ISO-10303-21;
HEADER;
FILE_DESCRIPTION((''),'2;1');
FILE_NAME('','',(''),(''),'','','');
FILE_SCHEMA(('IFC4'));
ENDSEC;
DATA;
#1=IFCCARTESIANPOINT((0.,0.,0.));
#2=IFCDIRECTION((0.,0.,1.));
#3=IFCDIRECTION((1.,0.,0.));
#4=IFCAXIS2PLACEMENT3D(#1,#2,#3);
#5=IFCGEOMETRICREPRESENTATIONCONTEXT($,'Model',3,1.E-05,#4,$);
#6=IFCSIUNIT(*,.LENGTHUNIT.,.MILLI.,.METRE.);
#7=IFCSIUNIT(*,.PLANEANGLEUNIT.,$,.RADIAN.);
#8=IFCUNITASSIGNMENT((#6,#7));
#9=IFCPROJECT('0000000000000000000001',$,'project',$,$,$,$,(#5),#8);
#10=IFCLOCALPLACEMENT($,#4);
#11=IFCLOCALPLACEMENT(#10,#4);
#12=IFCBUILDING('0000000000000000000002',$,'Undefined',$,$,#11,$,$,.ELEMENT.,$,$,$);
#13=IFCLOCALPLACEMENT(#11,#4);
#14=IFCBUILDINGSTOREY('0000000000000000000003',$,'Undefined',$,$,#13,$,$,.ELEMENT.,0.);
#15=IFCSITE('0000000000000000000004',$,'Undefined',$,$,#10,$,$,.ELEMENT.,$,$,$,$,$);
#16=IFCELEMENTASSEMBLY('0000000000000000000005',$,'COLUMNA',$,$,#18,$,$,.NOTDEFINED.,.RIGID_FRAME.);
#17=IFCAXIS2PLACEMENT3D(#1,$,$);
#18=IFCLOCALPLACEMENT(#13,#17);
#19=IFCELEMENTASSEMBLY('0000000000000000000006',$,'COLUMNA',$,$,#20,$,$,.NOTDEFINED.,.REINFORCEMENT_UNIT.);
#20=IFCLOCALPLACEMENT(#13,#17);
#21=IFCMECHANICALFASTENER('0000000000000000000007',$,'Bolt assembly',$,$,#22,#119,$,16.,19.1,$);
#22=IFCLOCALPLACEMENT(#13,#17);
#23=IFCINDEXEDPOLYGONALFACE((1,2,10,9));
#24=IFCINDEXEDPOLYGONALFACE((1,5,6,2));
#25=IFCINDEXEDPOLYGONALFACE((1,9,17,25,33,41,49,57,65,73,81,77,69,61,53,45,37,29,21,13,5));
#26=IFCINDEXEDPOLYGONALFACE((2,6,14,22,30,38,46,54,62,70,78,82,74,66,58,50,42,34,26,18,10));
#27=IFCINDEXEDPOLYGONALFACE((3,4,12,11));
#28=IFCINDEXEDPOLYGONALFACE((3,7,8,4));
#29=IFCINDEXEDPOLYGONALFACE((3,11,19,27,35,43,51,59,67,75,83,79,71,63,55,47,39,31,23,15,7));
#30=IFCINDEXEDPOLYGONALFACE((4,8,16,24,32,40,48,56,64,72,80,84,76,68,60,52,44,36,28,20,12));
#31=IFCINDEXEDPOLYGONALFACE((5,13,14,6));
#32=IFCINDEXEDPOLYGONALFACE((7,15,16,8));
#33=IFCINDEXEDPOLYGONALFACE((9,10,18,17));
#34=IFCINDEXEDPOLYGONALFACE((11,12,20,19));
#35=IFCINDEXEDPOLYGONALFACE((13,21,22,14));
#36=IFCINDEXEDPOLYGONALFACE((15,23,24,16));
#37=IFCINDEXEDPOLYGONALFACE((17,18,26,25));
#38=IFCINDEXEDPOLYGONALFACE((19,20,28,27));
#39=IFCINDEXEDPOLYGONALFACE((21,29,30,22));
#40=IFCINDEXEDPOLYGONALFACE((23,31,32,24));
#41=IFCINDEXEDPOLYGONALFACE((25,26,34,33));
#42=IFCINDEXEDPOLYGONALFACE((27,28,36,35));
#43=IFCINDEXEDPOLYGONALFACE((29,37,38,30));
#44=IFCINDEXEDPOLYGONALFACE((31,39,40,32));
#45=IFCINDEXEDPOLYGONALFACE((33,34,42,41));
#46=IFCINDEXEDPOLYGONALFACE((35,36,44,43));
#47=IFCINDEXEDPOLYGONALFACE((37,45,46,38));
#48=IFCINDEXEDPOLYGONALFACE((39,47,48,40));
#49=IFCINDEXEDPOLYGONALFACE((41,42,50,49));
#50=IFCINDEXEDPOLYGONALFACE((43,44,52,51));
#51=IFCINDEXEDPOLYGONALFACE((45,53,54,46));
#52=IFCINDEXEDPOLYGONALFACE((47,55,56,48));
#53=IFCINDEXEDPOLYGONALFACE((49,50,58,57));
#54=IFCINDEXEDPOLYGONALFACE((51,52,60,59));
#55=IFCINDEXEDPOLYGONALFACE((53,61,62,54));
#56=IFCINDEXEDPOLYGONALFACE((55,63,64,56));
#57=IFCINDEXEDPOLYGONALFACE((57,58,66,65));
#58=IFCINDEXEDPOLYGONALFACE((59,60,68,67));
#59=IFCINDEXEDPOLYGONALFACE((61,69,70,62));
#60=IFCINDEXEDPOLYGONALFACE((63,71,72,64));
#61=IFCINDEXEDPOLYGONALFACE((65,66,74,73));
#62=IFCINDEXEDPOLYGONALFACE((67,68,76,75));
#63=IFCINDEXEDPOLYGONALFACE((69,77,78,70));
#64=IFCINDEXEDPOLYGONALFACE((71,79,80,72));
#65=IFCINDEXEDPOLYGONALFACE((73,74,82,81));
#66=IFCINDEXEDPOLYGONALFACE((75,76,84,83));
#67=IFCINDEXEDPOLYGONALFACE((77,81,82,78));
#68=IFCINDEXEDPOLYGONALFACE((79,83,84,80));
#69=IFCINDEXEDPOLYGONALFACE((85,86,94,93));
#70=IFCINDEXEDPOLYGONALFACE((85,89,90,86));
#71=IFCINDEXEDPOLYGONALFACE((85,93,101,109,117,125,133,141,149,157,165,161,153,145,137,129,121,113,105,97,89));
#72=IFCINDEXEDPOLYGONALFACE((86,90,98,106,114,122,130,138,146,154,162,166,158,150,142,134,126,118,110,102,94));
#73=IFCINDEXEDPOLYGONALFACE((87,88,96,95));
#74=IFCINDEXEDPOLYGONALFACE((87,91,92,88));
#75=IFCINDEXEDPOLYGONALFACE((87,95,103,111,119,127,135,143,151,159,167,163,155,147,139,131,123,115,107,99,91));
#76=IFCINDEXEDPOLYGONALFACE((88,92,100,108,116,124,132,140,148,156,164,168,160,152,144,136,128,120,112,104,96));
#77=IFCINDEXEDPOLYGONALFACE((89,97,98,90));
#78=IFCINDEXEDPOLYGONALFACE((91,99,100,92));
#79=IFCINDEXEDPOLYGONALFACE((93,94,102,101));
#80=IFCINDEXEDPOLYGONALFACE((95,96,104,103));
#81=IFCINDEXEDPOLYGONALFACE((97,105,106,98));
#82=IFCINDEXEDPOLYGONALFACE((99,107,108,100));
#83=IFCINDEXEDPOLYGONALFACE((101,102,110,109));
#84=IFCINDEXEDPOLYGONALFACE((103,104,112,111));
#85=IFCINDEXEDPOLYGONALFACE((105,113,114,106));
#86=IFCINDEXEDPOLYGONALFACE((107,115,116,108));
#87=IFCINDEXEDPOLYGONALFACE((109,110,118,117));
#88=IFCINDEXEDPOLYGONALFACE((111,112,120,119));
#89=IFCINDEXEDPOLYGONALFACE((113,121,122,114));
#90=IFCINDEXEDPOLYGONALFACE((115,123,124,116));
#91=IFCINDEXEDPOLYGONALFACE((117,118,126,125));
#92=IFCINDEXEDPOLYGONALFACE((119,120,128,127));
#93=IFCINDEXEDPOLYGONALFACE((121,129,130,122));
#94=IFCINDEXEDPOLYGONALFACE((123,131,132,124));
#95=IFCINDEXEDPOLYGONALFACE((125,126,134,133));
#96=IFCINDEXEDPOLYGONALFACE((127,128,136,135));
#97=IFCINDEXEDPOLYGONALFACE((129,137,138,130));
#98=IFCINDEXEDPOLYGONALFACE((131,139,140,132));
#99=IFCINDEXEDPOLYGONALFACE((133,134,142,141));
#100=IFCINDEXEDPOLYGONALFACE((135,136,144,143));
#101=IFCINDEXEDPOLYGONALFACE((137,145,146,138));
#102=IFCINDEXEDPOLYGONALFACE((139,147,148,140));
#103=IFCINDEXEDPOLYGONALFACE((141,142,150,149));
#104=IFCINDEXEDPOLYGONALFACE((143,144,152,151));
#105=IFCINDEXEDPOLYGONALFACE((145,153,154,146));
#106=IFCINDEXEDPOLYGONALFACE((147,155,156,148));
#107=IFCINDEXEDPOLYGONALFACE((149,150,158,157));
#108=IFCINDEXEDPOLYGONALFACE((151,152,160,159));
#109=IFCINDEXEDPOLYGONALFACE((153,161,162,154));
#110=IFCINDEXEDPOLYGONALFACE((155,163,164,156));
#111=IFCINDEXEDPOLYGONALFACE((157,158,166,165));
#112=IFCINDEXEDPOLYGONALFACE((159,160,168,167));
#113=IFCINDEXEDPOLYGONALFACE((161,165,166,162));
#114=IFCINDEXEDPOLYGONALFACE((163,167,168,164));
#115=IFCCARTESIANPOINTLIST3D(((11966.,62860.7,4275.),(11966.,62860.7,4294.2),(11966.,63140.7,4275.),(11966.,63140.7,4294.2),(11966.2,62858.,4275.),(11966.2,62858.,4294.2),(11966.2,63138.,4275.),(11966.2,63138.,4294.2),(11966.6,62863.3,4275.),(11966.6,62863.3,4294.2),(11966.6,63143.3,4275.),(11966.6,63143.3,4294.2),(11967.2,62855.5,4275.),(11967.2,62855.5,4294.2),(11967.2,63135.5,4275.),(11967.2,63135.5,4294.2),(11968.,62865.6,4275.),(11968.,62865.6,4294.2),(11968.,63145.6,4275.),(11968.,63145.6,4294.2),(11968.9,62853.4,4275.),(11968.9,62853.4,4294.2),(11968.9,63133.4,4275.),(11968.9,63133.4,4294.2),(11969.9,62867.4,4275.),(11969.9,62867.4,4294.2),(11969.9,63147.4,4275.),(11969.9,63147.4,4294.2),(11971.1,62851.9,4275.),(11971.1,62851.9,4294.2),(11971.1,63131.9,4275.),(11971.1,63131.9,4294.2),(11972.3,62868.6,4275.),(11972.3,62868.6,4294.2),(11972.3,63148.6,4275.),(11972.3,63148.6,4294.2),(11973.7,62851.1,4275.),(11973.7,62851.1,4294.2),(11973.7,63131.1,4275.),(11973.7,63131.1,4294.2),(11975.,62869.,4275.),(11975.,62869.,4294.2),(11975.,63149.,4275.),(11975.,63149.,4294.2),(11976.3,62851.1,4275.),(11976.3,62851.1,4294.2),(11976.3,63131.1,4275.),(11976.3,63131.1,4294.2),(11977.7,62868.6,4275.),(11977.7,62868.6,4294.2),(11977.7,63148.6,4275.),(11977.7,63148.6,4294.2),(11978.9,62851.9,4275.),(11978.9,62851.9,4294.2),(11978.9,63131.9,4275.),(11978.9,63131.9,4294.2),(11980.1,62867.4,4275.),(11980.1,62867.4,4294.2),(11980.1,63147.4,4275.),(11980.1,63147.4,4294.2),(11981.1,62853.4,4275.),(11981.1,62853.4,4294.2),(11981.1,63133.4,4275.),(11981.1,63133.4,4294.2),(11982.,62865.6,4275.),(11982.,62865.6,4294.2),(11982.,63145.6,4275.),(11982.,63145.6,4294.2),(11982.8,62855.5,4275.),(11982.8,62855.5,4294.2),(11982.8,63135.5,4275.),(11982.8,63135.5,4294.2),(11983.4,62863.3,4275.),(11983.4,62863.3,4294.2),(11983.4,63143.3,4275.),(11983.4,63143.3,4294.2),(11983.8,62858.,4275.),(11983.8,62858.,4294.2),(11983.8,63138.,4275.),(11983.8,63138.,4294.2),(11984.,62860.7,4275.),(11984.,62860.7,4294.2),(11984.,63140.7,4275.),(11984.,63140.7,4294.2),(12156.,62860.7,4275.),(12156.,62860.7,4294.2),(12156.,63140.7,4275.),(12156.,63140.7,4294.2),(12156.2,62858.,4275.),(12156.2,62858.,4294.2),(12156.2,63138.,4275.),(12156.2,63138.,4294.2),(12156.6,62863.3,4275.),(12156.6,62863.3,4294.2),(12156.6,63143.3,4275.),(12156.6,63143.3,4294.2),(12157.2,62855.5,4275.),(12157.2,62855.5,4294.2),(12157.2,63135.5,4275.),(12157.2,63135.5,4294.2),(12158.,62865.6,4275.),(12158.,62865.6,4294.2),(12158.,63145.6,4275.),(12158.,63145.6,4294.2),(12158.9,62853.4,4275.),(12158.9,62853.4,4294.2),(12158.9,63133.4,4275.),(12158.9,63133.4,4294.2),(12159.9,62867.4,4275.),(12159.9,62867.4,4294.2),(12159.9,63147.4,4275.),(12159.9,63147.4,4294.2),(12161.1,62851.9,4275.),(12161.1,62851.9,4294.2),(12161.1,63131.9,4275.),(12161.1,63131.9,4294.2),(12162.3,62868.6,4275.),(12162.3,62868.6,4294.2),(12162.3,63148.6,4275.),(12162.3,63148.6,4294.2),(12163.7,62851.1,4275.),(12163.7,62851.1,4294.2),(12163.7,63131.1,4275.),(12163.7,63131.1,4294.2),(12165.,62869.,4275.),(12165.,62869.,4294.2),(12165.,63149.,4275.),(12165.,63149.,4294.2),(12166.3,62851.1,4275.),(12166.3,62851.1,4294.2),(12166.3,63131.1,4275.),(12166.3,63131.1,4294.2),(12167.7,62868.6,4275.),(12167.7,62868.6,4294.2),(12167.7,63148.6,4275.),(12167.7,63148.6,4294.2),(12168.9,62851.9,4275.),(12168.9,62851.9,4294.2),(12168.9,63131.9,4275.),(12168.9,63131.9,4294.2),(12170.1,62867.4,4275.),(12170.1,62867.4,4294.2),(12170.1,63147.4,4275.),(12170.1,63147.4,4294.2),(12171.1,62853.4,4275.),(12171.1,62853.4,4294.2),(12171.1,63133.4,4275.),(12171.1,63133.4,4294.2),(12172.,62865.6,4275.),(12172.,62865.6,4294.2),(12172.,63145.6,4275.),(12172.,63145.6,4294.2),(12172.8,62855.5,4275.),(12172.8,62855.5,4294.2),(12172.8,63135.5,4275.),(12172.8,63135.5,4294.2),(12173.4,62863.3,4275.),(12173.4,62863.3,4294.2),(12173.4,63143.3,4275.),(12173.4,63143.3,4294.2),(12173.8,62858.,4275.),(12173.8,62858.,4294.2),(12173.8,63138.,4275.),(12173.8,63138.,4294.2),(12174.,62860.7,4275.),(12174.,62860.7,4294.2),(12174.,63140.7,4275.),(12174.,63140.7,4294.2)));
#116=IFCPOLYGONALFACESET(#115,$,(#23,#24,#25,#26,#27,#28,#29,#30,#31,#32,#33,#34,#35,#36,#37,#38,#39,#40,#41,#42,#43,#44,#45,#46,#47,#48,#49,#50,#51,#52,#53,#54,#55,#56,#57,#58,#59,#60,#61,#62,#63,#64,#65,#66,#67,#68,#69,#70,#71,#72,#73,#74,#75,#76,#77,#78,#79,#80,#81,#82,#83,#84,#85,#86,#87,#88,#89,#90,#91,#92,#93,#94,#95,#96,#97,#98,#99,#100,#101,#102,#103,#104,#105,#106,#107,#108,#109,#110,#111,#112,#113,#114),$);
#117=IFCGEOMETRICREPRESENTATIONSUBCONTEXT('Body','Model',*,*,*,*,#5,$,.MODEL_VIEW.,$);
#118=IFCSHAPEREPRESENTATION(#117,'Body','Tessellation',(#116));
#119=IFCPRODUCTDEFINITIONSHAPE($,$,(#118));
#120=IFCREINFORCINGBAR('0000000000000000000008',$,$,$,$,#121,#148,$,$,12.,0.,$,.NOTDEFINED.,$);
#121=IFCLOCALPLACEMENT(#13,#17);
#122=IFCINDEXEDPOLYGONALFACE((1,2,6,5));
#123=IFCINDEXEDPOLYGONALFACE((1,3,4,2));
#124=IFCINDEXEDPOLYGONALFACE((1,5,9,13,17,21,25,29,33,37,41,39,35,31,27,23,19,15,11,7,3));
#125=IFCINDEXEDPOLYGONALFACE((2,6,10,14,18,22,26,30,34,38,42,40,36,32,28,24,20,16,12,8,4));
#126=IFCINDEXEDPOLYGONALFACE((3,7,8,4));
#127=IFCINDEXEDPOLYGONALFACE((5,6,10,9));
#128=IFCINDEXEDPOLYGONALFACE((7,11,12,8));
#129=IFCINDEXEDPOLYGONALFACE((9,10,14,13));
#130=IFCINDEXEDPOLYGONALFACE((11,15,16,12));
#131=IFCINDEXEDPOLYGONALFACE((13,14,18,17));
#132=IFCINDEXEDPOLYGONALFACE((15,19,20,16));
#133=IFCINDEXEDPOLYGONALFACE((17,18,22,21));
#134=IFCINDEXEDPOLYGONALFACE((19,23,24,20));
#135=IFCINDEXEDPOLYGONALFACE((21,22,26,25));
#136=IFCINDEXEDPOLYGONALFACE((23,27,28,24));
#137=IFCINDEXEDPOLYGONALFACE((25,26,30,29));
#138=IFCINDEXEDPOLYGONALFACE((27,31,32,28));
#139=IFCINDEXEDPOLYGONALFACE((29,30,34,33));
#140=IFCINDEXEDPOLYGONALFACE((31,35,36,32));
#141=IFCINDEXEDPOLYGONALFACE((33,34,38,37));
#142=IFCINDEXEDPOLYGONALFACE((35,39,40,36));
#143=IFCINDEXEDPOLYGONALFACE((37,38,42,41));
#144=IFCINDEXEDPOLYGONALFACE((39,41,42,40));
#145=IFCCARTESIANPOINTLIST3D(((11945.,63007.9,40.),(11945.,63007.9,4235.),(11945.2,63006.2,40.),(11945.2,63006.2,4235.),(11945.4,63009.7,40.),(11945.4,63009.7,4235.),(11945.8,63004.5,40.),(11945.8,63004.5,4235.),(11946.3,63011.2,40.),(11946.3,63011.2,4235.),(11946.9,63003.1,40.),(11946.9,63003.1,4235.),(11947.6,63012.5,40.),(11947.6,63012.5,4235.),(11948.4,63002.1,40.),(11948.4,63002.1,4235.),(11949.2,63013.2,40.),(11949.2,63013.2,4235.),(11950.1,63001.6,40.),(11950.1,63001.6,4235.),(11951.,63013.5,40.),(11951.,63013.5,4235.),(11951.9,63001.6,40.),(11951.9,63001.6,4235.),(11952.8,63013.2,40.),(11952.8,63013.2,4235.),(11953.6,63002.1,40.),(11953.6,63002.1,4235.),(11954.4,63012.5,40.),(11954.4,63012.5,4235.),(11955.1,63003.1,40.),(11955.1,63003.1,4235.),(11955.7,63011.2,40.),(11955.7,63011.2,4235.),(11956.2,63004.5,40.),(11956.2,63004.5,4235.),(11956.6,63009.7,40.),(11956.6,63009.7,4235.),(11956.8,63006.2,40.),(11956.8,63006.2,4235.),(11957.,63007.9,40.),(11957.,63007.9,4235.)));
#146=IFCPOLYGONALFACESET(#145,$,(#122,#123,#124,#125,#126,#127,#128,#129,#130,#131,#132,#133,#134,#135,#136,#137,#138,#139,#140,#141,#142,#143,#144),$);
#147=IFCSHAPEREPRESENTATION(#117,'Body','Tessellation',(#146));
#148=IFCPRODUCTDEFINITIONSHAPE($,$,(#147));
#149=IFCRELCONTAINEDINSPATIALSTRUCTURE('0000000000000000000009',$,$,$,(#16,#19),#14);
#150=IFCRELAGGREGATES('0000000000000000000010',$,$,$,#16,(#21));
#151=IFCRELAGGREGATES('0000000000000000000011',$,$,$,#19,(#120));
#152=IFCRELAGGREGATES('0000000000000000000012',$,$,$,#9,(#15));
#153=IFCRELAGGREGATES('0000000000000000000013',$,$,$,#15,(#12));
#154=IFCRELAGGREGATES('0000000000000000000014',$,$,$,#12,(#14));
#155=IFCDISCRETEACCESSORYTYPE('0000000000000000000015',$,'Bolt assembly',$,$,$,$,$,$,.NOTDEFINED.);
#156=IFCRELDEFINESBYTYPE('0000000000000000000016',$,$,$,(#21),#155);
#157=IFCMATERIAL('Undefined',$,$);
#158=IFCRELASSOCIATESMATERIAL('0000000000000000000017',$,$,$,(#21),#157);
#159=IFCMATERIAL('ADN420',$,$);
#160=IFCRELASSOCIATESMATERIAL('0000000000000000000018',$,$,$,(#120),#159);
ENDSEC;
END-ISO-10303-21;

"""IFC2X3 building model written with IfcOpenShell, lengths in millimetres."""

from ifc_helpers import new_model, entity, si_unit, frame, origin_with_axes, origin_2d_with_axis, place, context, subcontext, project, spatial, circle, extrude, source, transform, mapped, material, type_object, element, aggregate, save


model = new_model("IFC2X3")

# Units and contexts
model_context = context("Model", 3, precision=1e-05, world=origin_with_axes())
body_context = subcontext(model_context, "Body", "Model", "MODEL_VIEW")
ifc_project = project(units=[si_unit("LENGTHUNIT", "METRE", prefix="MILLI"), si_unit("PLANEANGLEUNIT", "RADIAN")], contexts=[model_context])

# Site, building, storey
site_placement = place(None, origin_with_axes())
site = spatial("IfcSite", under=ifc_project, at=site_placement, Name="Undefined", CompositionType="ELEMENT")
building_placement = place(site_placement, origin_with_axes())
building = spatial("IfcBuilding", under=site, at=building_placement, Name="Undefined", CompositionType="ELEMENT")
storey_placement = place(building_placement, origin_with_axes())
storey = spatial("IfcBuildingStorey", under=building, at=storey_placement, Name="Undefined", CompositionType="ELEMENT", Elevation=0.0)

# Element assembly
assembly_1_placement = place(storey_placement, origin_with_axes())
assembly_1 = element("IfcElementAssembly", 1, at=assembly_1_placement, inside=storey, Name="COLUMNA", AssemblyPlace="NOTDEFINED", PredefinedType="RIGID_FRAME")

# Element assembly
assembly_2_placement = place(storey_placement, origin_with_axes())
assembly_2 = element("IfcElementAssembly", 2, at=assembly_2_placement, inside=storey, Name="COLUMNA", AssemblyPlace="NOTDEFINED", PredefinedType="REINFORCEMENT_UNIT")

# Shared definitions
ifc_material_1 = material(Name="Undefined")
discrete_accessory_type_1 = type_object("IfcDiscreteAccessoryType", Name="Bolt assembly")

# Mechanical fastener
shared_shape_1 = source(origin_with_axes(), body_context, "Body", "SweptSolid", [
    extrude(circle(Radius=9.0, at=origin_2d_with_axis()), frame((0.0, -19.1, 0.0), z_axis=(0.0, 1.0, 0.0), x_axis=(1.0, 0.0, 0.0)), (0.0, 0.0, 1.0), 19.2),
])
mechanical_fastener_1_placement = place(assembly_1_placement, frame((12070.0, 62905.0, 4294.1), z_axis=(1.0, 0.0, 0.0), x_axis=(0.0, 1.0, 0.0)))
mechanical_fastener_1 = element("IfcMechanicalFastener", 3, at=mechanical_fastener_1_placement, type_object=discrete_accessory_type_1, material=ifc_material_1, Name="Bolt assembly", NominalDiameter=16.0, NominalLength=19.1, context=body_context, shape_type="MappedRepresentation", body=[
    mapped(shared_shape_1, transform((-45.0, 0.0, -95.0))),
    mapped(shared_shape_1, transform((-45.0, 0.0, 95.0))),
    mapped(shared_shape_1, transform((235.0, 0.0, -95.0))),
    mapped(shared_shape_1, transform((235.0, 0.0, 95.0))),
])
aggregate(assembly_1, [mechanical_fastener_1])

# Reinforcing bar
ifc_material_2 = material(Name="ADN420")
shared_shape_2 = source(origin_with_axes(), body_context, "Body", "AdvancedSweptSolid", [
    entity("IfcSweptDiskSolid", entity("IfcTrimmedCurve", entity("IfcLine", entity("IfcCartesianPoint", [0.0, 0.0, 0.0]), entity("IfcVector", entity("IfcDirection", [1.0, 0.0, 0.0]), 1.0)), [entity("IfcParameterValue", 0.0)], [entity("IfcParameterValue", 4195.0)], True, "PARAMETER"), 6.0, None, 0.0, 4195.0),
])
reinforcing_bar_1_placement = place(assembly_2_placement, frame((11951.0, 63007.5, 4235.0), z_axis=(0.0, 1.0, 0.0), x_axis=(0.0, 0.0, -1.0)))
reinforcing_bar_1 = element("IfcReinforcingBar", 4, at=reinforcing_bar_1_placement, material=ifc_material_2, BarRole="NOTDEFINED", CrossSectionArea=0.0, NominalDiameter=12.0, context=body_context, shape_type="MappedRepresentation", body=[
    mapped(shared_shape_2, transform((0.0, 0.0, 0.0))),
])
aggregate(assembly_2, [reinforcing_bar_1])

save(model, "model.ifc")
